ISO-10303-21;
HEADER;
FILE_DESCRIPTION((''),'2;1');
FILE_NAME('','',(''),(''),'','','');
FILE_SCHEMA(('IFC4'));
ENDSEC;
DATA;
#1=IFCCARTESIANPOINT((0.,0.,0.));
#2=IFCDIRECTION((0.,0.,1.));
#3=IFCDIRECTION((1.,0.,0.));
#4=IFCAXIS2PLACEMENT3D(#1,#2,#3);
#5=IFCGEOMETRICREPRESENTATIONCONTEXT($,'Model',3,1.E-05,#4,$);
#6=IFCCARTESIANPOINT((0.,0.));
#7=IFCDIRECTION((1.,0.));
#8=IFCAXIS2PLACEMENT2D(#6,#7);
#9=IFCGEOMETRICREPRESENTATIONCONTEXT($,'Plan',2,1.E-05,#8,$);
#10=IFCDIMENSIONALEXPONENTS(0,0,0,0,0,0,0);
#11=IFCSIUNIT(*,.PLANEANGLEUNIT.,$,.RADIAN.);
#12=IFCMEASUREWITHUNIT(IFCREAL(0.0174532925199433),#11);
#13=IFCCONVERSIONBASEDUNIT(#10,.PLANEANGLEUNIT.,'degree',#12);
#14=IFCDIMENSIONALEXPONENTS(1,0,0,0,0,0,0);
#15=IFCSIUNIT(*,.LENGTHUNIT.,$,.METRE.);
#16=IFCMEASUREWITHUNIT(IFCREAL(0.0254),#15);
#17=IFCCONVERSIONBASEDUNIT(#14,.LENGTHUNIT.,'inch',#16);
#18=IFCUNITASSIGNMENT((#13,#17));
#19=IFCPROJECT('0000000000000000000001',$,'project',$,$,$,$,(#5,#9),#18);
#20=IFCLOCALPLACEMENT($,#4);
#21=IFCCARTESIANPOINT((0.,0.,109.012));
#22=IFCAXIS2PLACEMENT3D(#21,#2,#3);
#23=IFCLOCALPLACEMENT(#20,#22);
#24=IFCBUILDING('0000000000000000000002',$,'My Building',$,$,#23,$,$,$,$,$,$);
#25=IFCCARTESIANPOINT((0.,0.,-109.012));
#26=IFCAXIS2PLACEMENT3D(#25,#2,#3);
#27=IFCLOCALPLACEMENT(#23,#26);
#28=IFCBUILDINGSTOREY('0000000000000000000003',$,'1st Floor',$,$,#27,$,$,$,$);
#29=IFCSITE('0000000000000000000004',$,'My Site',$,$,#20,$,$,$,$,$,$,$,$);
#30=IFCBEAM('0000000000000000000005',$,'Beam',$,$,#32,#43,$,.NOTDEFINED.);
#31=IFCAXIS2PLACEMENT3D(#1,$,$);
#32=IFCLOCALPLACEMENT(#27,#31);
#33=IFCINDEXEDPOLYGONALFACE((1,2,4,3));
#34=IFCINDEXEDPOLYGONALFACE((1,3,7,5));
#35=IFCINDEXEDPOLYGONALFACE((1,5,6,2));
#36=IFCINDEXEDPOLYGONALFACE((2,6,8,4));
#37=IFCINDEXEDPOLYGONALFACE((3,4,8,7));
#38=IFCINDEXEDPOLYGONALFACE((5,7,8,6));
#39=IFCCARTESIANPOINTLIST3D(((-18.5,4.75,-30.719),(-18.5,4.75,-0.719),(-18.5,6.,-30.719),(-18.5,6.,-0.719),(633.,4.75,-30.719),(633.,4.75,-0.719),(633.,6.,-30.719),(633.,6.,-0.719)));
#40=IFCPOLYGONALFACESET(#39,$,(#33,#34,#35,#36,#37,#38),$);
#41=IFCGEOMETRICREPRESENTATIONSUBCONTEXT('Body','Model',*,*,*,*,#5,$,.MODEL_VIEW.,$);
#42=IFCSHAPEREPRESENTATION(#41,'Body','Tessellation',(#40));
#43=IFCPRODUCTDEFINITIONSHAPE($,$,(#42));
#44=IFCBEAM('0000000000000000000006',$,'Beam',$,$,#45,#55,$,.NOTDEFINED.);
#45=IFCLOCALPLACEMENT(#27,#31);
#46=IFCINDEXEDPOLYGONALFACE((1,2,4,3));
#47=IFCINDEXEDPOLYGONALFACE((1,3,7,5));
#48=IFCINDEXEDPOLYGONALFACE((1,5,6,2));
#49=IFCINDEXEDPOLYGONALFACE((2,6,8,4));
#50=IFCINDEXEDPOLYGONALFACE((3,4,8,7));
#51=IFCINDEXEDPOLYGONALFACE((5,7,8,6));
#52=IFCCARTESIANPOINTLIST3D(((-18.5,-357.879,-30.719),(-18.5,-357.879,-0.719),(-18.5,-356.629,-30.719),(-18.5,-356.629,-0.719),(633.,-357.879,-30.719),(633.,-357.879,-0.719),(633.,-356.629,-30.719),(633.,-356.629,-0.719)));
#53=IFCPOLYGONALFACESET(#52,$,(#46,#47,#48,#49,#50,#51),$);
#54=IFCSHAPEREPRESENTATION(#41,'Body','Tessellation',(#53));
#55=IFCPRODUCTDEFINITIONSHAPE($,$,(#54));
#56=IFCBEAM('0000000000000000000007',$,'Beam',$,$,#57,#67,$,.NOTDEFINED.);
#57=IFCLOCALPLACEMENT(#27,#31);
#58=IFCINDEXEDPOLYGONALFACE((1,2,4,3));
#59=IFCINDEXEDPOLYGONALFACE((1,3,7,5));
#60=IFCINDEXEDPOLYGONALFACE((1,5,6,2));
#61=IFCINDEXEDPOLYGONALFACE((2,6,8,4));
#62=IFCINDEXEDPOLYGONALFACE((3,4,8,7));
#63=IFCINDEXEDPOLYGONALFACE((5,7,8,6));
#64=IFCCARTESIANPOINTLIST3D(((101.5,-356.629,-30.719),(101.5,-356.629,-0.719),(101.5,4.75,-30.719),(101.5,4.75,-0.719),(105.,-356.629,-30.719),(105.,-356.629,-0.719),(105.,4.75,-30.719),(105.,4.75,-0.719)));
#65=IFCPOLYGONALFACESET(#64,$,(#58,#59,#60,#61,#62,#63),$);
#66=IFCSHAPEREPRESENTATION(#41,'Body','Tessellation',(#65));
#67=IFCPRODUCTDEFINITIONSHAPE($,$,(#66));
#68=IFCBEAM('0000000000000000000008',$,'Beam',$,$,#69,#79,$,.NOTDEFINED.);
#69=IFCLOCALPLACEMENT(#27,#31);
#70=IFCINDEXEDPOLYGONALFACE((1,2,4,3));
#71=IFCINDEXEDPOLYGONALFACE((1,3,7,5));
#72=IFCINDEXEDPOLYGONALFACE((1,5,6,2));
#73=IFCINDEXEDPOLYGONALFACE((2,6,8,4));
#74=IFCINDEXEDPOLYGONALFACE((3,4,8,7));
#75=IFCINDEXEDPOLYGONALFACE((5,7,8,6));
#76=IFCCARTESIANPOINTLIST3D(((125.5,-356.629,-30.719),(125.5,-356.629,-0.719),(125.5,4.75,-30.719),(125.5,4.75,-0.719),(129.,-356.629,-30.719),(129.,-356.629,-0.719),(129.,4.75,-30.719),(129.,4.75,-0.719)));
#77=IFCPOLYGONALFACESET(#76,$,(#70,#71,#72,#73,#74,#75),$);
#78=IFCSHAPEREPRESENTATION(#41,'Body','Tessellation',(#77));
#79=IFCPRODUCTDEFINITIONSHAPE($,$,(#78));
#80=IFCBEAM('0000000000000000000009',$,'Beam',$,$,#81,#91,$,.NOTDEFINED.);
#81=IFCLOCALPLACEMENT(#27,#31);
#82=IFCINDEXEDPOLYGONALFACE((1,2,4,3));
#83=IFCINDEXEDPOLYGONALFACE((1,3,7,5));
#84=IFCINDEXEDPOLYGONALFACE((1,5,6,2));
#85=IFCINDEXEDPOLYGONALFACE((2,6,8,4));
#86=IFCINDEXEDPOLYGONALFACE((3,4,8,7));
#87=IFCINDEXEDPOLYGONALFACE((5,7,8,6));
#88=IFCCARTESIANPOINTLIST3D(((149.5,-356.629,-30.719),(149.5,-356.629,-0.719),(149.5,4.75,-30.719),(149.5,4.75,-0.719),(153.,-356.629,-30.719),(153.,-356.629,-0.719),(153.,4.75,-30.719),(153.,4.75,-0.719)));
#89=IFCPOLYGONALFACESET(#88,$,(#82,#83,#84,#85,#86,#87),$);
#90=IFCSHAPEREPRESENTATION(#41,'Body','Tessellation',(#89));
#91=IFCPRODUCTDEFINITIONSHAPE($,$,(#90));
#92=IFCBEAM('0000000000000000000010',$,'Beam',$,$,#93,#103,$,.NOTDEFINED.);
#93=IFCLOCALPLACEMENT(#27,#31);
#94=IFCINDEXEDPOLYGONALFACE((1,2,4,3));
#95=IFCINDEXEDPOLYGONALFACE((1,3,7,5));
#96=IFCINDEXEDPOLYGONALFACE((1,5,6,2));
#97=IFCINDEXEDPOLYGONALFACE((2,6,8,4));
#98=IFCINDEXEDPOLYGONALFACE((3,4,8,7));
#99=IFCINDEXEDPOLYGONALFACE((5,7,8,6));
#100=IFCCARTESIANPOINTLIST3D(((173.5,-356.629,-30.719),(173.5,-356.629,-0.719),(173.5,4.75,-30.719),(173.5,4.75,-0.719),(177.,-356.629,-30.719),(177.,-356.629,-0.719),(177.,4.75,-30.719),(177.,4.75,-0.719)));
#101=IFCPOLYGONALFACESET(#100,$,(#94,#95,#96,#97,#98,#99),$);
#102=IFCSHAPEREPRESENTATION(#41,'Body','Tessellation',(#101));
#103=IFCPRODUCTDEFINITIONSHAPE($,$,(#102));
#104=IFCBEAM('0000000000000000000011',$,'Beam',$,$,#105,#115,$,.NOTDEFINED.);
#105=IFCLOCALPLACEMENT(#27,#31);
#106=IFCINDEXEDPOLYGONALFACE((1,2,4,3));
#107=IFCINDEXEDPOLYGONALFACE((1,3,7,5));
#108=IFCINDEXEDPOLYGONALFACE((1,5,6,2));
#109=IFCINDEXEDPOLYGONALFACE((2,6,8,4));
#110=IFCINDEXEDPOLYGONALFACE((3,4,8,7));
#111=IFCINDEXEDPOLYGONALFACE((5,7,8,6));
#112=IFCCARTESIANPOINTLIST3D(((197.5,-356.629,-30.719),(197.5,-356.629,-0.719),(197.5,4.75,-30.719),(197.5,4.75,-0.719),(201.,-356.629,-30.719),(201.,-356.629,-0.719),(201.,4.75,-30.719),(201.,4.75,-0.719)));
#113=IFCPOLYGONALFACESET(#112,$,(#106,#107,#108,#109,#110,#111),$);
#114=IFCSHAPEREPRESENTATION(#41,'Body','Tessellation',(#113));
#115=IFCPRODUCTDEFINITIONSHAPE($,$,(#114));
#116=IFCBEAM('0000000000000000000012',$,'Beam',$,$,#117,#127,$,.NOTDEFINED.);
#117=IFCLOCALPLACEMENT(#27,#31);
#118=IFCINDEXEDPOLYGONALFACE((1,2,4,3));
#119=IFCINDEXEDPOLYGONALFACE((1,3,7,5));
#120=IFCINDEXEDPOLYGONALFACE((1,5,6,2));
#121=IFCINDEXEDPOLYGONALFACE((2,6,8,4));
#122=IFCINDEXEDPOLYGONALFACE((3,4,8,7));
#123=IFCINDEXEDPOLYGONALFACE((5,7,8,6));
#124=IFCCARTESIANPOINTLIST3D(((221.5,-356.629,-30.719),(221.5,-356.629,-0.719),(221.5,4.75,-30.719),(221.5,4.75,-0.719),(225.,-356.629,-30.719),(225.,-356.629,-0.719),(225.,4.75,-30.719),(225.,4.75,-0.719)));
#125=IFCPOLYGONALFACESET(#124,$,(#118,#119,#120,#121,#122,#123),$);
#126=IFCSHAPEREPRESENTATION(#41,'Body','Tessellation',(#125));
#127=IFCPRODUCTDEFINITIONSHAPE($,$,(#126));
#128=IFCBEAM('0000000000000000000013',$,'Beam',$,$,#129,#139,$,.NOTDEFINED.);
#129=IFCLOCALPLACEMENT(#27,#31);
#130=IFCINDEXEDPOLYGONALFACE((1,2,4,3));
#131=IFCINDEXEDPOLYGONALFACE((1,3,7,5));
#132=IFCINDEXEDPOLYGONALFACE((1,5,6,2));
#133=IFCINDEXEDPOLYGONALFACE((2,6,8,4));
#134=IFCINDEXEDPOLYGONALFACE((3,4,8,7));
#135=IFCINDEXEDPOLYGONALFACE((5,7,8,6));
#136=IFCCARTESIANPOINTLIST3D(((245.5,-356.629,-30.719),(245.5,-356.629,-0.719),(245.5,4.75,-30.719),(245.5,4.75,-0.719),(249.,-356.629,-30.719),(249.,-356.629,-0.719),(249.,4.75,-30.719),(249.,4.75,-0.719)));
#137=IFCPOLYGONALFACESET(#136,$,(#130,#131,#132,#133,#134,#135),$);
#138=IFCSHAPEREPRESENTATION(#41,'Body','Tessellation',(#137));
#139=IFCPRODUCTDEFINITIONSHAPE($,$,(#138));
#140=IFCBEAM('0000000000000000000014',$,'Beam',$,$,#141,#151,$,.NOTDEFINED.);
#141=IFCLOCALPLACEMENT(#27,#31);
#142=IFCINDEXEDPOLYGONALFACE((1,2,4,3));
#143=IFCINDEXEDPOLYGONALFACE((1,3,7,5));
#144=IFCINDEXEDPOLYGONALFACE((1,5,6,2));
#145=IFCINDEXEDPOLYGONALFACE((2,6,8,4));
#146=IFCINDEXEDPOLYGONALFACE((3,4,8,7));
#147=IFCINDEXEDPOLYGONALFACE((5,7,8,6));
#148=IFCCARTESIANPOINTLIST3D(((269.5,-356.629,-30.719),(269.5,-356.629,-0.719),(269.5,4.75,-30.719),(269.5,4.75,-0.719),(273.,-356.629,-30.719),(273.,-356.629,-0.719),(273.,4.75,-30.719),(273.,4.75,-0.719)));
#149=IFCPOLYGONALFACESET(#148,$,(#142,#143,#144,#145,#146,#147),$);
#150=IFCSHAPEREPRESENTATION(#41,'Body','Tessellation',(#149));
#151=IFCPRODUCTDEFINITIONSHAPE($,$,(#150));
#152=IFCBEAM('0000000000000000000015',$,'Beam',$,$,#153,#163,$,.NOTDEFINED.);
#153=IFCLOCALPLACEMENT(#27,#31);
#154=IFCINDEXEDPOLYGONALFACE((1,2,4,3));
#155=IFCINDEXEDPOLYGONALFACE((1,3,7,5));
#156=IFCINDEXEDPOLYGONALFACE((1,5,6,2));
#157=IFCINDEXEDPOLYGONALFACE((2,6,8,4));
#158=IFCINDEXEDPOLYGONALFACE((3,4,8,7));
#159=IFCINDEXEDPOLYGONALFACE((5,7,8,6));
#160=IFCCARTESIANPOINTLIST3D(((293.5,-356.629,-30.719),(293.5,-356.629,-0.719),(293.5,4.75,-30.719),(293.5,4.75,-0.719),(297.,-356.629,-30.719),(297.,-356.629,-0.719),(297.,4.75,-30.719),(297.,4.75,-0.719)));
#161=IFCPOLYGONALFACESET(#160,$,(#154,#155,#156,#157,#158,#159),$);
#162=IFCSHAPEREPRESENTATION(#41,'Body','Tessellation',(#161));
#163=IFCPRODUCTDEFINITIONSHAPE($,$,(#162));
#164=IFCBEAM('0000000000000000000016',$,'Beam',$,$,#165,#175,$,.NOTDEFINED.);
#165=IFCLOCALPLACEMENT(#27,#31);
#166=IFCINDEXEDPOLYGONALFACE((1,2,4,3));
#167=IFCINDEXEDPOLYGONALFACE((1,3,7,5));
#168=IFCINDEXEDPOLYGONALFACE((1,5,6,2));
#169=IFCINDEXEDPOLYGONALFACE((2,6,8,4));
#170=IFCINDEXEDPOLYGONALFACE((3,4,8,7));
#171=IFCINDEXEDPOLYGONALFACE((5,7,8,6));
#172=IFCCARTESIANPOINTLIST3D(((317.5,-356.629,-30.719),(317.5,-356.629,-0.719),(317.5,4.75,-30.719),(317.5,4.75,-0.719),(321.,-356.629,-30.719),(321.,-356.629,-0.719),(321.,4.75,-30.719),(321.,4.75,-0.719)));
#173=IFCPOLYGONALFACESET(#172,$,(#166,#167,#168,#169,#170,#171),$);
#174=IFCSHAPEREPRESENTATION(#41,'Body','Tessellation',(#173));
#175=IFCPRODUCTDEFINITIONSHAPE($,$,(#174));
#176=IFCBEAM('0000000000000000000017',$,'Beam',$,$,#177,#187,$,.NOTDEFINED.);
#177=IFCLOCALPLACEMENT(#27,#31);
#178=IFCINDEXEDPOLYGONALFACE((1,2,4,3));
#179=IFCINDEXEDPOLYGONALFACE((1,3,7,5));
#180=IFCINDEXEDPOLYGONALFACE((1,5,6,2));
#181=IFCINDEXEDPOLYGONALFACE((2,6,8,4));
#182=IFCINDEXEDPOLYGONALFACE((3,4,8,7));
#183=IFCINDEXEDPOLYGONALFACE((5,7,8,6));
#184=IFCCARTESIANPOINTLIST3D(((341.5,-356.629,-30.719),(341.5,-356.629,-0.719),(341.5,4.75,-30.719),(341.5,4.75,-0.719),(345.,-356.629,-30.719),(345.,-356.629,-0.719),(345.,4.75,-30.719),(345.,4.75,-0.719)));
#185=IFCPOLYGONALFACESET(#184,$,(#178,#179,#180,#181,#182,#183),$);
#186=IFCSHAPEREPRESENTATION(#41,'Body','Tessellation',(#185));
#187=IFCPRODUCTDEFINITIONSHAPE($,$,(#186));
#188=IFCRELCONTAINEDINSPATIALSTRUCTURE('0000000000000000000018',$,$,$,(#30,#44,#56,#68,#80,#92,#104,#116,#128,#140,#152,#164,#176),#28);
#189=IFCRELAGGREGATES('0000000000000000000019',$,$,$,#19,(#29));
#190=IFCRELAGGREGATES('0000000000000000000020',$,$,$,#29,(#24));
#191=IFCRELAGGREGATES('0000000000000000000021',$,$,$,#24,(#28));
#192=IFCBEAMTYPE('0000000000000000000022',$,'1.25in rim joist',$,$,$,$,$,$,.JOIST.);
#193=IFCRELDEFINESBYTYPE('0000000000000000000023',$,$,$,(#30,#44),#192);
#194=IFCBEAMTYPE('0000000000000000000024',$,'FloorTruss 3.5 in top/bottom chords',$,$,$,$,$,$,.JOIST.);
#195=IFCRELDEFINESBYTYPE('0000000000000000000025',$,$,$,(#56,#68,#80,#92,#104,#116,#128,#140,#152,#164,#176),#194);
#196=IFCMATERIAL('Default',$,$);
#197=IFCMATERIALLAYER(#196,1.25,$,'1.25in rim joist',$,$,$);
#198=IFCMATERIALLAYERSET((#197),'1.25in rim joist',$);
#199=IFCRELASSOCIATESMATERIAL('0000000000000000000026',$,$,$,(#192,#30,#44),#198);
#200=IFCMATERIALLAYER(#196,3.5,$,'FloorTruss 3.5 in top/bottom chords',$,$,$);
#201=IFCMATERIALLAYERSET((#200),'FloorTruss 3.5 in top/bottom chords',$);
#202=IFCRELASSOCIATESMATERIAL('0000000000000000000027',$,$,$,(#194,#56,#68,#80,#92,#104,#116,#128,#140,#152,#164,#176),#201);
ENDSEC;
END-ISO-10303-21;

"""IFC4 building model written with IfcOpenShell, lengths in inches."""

from ifc_helpers import new_model, entity, si_unit, converted_unit, frame, origin_with_axes, origin_2d_with_axis, place, context, subcontext, project, spatial, indexed_curve, outline, extrude, material, layer, layer_set, layer_usage, type_object, element, save


model = new_model("IFC4")

# Units and contexts
model_context = context("Model", 3, precision=1e-05, world=origin_with_axes())
plan_context = context("Plan", 2, precision=1e-05, world=origin_2d_with_axis())
body_context = subcontext(model_context, "Body", "Model", "MODEL_VIEW")
ifc_project = project(units=[converted_unit("PLANEANGLEUNIT", "degree", entity("IfcReal", 0.0174532925199433), si_unit("PLANEANGLEUNIT", "RADIAN"), dimensions=[0, 0, 0, 0, 0, 0, 0]), converted_unit("LENGTHUNIT", "inch", entity("IfcReal", 0.0254), si_unit("LENGTHUNIT", "METRE"), dimensions=[1, 0, 0, 0, 0, 0, 0])], contexts=[model_context, plan_context])

# Site, building, storey
site_placement = place(None, origin_with_axes())
site = spatial("IfcSite", under=ifc_project, at=site_placement, Name="My Site")
building_placement = place(site_placement, frame((0.0, 0.0, 109.012), z_axis=(0.0, 0.0, 1.0), x_axis=(1.0, 0.0, 0.0)))
building = spatial("IfcBuilding", under=site, at=building_placement, Name="My Building")
storey_placement = place(building_placement, frame((0.0, 0.0, -109.012), z_axis=(0.0, 0.0, 1.0), x_axis=(1.0, 0.0, 0.0)))
storey = spatial("IfcBuildingStorey", under=building, at=storey_placement, Name="1st Floor")

# Beams
ifc_material = material(Name="Default")
ifc_layer_1 = layer(ifc_material, 1.25, Name="1.25in rim joist")
ifc_layer_set_1 = layer_set([ifc_layer_1], Name="1.25in rim joist")
ifc_layer_usage_1 = layer_usage(ifc_layer_set_1, "AXIS2", "POSITIVE", 0.0)
beam_type_1 = type_object("IfcBeamType", Name="1.25in rim joist", PredefinedType="JOIST", material=ifc_layer_set_1)
beam_1_placement = place(storey_placement, frame((-18.5, 4.75, -30.719), z_axis=(0.0, 0.0, 1.0), x_axis=(1.0, 0.0, 0.0)))
element("IfcBeam", 1, at=beam_1_placement, inside=storey, type_object=beam_type_1, material=ifc_layer_usage_1, Name="Beam", PredefinedType="NOTDEFINED", context=body_context, shape_type="SweptSolid", body=[
    extrude(outline(indexed_curve([(0.0, 0.0), (0.0, 1.25), (651.5, 1.25), (651.5, 0.0), (0.0, 0.0)], self_intersect=False)), origin_with_axes(), (0.0, 0.0, 1.0), 30.0),
])
ifc_layer_usage_2 = layer_usage(ifc_layer_set_1, "AXIS2", "POSITIVE", 0.0)
beam_2_placement = place(storey_placement, frame((-18.5, -357.879, -30.719), z_axis=(0.0, 0.0, 1.0), x_axis=(1.0, 0.0, 0.0)))
element("IfcBeam", 2, at=beam_2_placement, inside=storey, type_object=beam_type_1, material=ifc_layer_usage_2, Name="Beam", PredefinedType="NOTDEFINED", context=body_context, shape_type="SweptSolid", body=[
    extrude(outline(indexed_curve([(0.0, 0.0), (0.0, 1.25), (651.5, 1.25), (651.5, 0.0), (0.0, 0.0)], self_intersect=False)), origin_with_axes(), (0.0, 0.0, 1.0), 30.0),
])
ifc_layer_2 = layer(ifc_material, 3.5, Name="FloorTruss 3.5 in top/bottom chords")
ifc_layer_set_2 = layer_set([ifc_layer_2], Name="FloorTruss 3.5 in top/bottom chords")
ifc_layer_usage_3 = layer_usage(ifc_layer_set_2, "AXIS2", "POSITIVE", 0.0)
beam_type_2 = type_object("IfcBeamType", Name="FloorTruss 3.5 in top/bottom chords", PredefinedType="JOIST", material=ifc_layer_set_2)
beam_3_placement = place(storey_placement, frame((105.0, -356.629, -30.719), z_axis=(0.0, 0.0, 1.0), x_axis=(0.0, 1.0, 0.0)))
element("IfcBeam", 3, at=beam_3_placement, inside=storey, type_object=beam_type_2, material=ifc_layer_usage_3, Name="Beam", PredefinedType="NOTDEFINED", context=body_context, shape_type="SweptSolid", body=[
    extrude(outline(indexed_curve([(0.0, 0.0), (0.0, 3.5), (361.379, 3.5), (361.379, 0.0), (0.0, 0.0)], self_intersect=False)), origin_with_axes(), (0.0, 0.0, 1.0), 30.0),
])
ifc_layer_usage_4 = layer_usage(ifc_layer_set_2, "AXIS2", "POSITIVE", 0.0)
beam_4_placement = place(storey_placement, frame((129.0, -356.629, -30.719), z_axis=(0.0, 0.0, 1.0), x_axis=(0.0, 1.0, 0.0)))
element("IfcBeam", 4, at=beam_4_placement, inside=storey, type_object=beam_type_2, material=ifc_layer_usage_4, Name="Beam", PredefinedType="NOTDEFINED", context=body_context, shape_type="SweptSolid", body=[
    extrude(outline(indexed_curve([(0.0, 0.0), (0.0, 3.5), (361.379, 3.5), (361.379, 0.0), (0.0, 0.0)], self_intersect=False)), origin_with_axes(), (0.0, 0.0, 1.0), 30.0),
])
ifc_layer_usage_5 = layer_usage(ifc_layer_set_2, "AXIS2", "POSITIVE", 0.0)
beam_5_placement = place(storey_placement, frame((153.0, -356.629, -30.719), z_axis=(0.0, 0.0, 1.0), x_axis=(0.0, 1.0, 0.0)))
element("IfcBeam", 5, at=beam_5_placement, inside=storey, type_object=beam_type_2, material=ifc_layer_usage_5, Name="Beam", PredefinedType="NOTDEFINED", context=body_context, shape_type="SweptSolid", body=[
    extrude(outline(indexed_curve([(0.0, 0.0), (0.0, 3.5), (361.379, 3.5), (361.379, 0.0), (0.0, 0.0)], self_intersect=False)), origin_with_axes(), (0.0, 0.0, 1.0), 30.0),
])
ifc_layer_usage_6 = layer_usage(ifc_layer_set_2, "AXIS2", "POSITIVE", 0.0)
beam_6_placement = place(storey_placement, frame((177.0, -356.629, -30.719), z_axis=(0.0, 0.0, 1.0), x_axis=(0.0, 1.0, 0.0)))
element("IfcBeam", 6, at=beam_6_placement, inside=storey, type_object=beam_type_2, material=ifc_layer_usage_6, Name="Beam", PredefinedType="NOTDEFINED", context=body_context, shape_type="SweptSolid", body=[
    extrude(outline(indexed_curve([(0.0, 0.0), (0.0, 3.5), (361.379, 3.5), (361.379, 0.0), (0.0, 0.0)], self_intersect=False)), origin_with_axes(), (0.0, 0.0, 1.0), 30.0),
])
ifc_layer_usage_7 = layer_usage(ifc_layer_set_2, "AXIS2", "POSITIVE", 0.0)
beam_7_placement = place(storey_placement, frame((201.0, -356.629, -30.719), z_axis=(0.0, 0.0, 1.0), x_axis=(0.0, 1.0, 0.0)))
element("IfcBeam", 7, at=beam_7_placement, inside=storey, type_object=beam_type_2, material=ifc_layer_usage_7, Name="Beam", PredefinedType="NOTDEFINED", context=body_context, shape_type="SweptSolid", body=[
    extrude(outline(indexed_curve([(0.0, 0.0), (0.0, 3.5), (361.379, 3.5), (361.379, 0.0), (0.0, 0.0)], self_intersect=False)), origin_with_axes(), (0.0, 0.0, 1.0), 30.0),
])
ifc_layer_usage_8 = layer_usage(ifc_layer_set_2, "AXIS2", "POSITIVE", 0.0)
beam_8_placement = place(storey_placement, frame((225.0, -356.629, -30.719), z_axis=(0.0, 0.0, 1.0), x_axis=(0.0, 1.0, 0.0)))
element("IfcBeam", 8, at=beam_8_placement, inside=storey, type_object=beam_type_2, material=ifc_layer_usage_8, Name="Beam", PredefinedType="NOTDEFINED", context=body_context, shape_type="SweptSolid", body=[
    extrude(outline(indexed_curve([(0.0, 0.0), (0.0, 3.5), (361.379, 3.5), (361.379, 0.0), (0.0, 0.0)], self_intersect=False)), origin_with_axes(), (0.0, 0.0, 1.0), 30.0),
])
ifc_layer_usage_9 = layer_usage(ifc_layer_set_2, "AXIS2", "POSITIVE", 0.0)
beam_9_placement = place(storey_placement, frame((249.0, -356.629, -30.719), z_axis=(0.0, 0.0, 1.0), x_axis=(0.0, 1.0, 0.0)))
element("IfcBeam", 9, at=beam_9_placement, inside=storey, type_object=beam_type_2, material=ifc_layer_usage_9, Name="Beam", PredefinedType="NOTDEFINED", context=body_context, shape_type="SweptSolid", body=[
    extrude(outline(indexed_curve([(0.0, 0.0), (0.0, 3.5), (361.379, 3.5), (361.379, 0.0), (0.0, 0.0)], self_intersect=False)), origin_with_axes(), (0.0, 0.0, 1.0), 30.0),
])
ifc_layer_usage_10 = layer_usage(ifc_layer_set_2, "AXIS2", "POSITIVE", 0.0)
beam_10_placement = place(storey_placement, frame((273.0, -356.629, -30.719), z_axis=(0.0, 0.0, 1.0), x_axis=(0.0, 1.0, 0.0)))
element("IfcBeam", 10, at=beam_10_placement, inside=storey, type_object=beam_type_2, material=ifc_layer_usage_10, Name="Beam", PredefinedType="NOTDEFINED", context=body_context, shape_type="SweptSolid", body=[
    extrude(outline(indexed_curve([(0.0, 0.0), (0.0, 3.5), (361.379, 3.5), (361.379, 0.0), (0.0, 0.0)], self_intersect=False)), origin_with_axes(), (0.0, 0.0, 1.0), 30.0),
])
ifc_layer_usage_11 = layer_usage(ifc_layer_set_2, "AXIS2", "POSITIVE", 0.0)
beam_11_placement = place(storey_placement, frame((297.0, -356.629, -30.719), z_axis=(0.0, 0.0, 1.0), x_axis=(0.0, 1.0, 0.0)))
element("IfcBeam", 11, at=beam_11_placement, inside=storey, type_object=beam_type_2, material=ifc_layer_usage_11, Name="Beam", PredefinedType="NOTDEFINED", context=body_context, shape_type="SweptSolid", body=[
    extrude(outline(indexed_curve([(0.0, 0.0), (0.0, 3.5), (361.379, 3.5), (361.379, 0.0), (0.0, 0.0)], self_intersect=False)), origin_with_axes(), (0.0, 0.0, 1.0), 30.0),
])
ifc_layer_usage_12 = layer_usage(ifc_layer_set_2, "AXIS2", "POSITIVE", 0.0)
beam_12_placement = place(storey_placement, frame((321.0, -356.629, -30.719), z_axis=(0.0, 0.0, 1.0), x_axis=(0.0, 1.0, 0.0)))
element("IfcBeam", 12, at=beam_12_placement, inside=storey, type_object=beam_type_2, material=ifc_layer_usage_12, Name="Beam", PredefinedType="NOTDEFINED", context=body_context, shape_type="SweptSolid", body=[
    extrude(outline(indexed_curve([(0.0, 0.0), (0.0, 3.5), (361.379, 3.5), (361.379, 0.0), (0.0, 0.0)], self_intersect=False)), origin_with_axes(), (0.0, 0.0, 1.0), 30.0),
])
ifc_layer_usage_13 = layer_usage(ifc_layer_set_2, "AXIS2", "POSITIVE", 0.0)
beam_13_placement = place(storey_placement, frame((345.0, -356.629, -30.719), z_axis=(0.0, 0.0, 1.0), x_axis=(0.0, 1.0, 0.0)))
element("IfcBeam", 13, at=beam_13_placement, inside=storey, type_object=beam_type_2, material=ifc_layer_usage_13, Name="Beam", PredefinedType="NOTDEFINED", context=body_context, shape_type="SweptSolid", body=[
    extrude(outline(indexed_curve([(0.0, 0.0), (0.0, 3.5), (361.379, 3.5), (361.379, 0.0), (0.0, 0.0)], self_intersect=False)), origin_with_axes(), (0.0, 0.0, 1.0), 30.0),
])

save(model, "model.ifc")
